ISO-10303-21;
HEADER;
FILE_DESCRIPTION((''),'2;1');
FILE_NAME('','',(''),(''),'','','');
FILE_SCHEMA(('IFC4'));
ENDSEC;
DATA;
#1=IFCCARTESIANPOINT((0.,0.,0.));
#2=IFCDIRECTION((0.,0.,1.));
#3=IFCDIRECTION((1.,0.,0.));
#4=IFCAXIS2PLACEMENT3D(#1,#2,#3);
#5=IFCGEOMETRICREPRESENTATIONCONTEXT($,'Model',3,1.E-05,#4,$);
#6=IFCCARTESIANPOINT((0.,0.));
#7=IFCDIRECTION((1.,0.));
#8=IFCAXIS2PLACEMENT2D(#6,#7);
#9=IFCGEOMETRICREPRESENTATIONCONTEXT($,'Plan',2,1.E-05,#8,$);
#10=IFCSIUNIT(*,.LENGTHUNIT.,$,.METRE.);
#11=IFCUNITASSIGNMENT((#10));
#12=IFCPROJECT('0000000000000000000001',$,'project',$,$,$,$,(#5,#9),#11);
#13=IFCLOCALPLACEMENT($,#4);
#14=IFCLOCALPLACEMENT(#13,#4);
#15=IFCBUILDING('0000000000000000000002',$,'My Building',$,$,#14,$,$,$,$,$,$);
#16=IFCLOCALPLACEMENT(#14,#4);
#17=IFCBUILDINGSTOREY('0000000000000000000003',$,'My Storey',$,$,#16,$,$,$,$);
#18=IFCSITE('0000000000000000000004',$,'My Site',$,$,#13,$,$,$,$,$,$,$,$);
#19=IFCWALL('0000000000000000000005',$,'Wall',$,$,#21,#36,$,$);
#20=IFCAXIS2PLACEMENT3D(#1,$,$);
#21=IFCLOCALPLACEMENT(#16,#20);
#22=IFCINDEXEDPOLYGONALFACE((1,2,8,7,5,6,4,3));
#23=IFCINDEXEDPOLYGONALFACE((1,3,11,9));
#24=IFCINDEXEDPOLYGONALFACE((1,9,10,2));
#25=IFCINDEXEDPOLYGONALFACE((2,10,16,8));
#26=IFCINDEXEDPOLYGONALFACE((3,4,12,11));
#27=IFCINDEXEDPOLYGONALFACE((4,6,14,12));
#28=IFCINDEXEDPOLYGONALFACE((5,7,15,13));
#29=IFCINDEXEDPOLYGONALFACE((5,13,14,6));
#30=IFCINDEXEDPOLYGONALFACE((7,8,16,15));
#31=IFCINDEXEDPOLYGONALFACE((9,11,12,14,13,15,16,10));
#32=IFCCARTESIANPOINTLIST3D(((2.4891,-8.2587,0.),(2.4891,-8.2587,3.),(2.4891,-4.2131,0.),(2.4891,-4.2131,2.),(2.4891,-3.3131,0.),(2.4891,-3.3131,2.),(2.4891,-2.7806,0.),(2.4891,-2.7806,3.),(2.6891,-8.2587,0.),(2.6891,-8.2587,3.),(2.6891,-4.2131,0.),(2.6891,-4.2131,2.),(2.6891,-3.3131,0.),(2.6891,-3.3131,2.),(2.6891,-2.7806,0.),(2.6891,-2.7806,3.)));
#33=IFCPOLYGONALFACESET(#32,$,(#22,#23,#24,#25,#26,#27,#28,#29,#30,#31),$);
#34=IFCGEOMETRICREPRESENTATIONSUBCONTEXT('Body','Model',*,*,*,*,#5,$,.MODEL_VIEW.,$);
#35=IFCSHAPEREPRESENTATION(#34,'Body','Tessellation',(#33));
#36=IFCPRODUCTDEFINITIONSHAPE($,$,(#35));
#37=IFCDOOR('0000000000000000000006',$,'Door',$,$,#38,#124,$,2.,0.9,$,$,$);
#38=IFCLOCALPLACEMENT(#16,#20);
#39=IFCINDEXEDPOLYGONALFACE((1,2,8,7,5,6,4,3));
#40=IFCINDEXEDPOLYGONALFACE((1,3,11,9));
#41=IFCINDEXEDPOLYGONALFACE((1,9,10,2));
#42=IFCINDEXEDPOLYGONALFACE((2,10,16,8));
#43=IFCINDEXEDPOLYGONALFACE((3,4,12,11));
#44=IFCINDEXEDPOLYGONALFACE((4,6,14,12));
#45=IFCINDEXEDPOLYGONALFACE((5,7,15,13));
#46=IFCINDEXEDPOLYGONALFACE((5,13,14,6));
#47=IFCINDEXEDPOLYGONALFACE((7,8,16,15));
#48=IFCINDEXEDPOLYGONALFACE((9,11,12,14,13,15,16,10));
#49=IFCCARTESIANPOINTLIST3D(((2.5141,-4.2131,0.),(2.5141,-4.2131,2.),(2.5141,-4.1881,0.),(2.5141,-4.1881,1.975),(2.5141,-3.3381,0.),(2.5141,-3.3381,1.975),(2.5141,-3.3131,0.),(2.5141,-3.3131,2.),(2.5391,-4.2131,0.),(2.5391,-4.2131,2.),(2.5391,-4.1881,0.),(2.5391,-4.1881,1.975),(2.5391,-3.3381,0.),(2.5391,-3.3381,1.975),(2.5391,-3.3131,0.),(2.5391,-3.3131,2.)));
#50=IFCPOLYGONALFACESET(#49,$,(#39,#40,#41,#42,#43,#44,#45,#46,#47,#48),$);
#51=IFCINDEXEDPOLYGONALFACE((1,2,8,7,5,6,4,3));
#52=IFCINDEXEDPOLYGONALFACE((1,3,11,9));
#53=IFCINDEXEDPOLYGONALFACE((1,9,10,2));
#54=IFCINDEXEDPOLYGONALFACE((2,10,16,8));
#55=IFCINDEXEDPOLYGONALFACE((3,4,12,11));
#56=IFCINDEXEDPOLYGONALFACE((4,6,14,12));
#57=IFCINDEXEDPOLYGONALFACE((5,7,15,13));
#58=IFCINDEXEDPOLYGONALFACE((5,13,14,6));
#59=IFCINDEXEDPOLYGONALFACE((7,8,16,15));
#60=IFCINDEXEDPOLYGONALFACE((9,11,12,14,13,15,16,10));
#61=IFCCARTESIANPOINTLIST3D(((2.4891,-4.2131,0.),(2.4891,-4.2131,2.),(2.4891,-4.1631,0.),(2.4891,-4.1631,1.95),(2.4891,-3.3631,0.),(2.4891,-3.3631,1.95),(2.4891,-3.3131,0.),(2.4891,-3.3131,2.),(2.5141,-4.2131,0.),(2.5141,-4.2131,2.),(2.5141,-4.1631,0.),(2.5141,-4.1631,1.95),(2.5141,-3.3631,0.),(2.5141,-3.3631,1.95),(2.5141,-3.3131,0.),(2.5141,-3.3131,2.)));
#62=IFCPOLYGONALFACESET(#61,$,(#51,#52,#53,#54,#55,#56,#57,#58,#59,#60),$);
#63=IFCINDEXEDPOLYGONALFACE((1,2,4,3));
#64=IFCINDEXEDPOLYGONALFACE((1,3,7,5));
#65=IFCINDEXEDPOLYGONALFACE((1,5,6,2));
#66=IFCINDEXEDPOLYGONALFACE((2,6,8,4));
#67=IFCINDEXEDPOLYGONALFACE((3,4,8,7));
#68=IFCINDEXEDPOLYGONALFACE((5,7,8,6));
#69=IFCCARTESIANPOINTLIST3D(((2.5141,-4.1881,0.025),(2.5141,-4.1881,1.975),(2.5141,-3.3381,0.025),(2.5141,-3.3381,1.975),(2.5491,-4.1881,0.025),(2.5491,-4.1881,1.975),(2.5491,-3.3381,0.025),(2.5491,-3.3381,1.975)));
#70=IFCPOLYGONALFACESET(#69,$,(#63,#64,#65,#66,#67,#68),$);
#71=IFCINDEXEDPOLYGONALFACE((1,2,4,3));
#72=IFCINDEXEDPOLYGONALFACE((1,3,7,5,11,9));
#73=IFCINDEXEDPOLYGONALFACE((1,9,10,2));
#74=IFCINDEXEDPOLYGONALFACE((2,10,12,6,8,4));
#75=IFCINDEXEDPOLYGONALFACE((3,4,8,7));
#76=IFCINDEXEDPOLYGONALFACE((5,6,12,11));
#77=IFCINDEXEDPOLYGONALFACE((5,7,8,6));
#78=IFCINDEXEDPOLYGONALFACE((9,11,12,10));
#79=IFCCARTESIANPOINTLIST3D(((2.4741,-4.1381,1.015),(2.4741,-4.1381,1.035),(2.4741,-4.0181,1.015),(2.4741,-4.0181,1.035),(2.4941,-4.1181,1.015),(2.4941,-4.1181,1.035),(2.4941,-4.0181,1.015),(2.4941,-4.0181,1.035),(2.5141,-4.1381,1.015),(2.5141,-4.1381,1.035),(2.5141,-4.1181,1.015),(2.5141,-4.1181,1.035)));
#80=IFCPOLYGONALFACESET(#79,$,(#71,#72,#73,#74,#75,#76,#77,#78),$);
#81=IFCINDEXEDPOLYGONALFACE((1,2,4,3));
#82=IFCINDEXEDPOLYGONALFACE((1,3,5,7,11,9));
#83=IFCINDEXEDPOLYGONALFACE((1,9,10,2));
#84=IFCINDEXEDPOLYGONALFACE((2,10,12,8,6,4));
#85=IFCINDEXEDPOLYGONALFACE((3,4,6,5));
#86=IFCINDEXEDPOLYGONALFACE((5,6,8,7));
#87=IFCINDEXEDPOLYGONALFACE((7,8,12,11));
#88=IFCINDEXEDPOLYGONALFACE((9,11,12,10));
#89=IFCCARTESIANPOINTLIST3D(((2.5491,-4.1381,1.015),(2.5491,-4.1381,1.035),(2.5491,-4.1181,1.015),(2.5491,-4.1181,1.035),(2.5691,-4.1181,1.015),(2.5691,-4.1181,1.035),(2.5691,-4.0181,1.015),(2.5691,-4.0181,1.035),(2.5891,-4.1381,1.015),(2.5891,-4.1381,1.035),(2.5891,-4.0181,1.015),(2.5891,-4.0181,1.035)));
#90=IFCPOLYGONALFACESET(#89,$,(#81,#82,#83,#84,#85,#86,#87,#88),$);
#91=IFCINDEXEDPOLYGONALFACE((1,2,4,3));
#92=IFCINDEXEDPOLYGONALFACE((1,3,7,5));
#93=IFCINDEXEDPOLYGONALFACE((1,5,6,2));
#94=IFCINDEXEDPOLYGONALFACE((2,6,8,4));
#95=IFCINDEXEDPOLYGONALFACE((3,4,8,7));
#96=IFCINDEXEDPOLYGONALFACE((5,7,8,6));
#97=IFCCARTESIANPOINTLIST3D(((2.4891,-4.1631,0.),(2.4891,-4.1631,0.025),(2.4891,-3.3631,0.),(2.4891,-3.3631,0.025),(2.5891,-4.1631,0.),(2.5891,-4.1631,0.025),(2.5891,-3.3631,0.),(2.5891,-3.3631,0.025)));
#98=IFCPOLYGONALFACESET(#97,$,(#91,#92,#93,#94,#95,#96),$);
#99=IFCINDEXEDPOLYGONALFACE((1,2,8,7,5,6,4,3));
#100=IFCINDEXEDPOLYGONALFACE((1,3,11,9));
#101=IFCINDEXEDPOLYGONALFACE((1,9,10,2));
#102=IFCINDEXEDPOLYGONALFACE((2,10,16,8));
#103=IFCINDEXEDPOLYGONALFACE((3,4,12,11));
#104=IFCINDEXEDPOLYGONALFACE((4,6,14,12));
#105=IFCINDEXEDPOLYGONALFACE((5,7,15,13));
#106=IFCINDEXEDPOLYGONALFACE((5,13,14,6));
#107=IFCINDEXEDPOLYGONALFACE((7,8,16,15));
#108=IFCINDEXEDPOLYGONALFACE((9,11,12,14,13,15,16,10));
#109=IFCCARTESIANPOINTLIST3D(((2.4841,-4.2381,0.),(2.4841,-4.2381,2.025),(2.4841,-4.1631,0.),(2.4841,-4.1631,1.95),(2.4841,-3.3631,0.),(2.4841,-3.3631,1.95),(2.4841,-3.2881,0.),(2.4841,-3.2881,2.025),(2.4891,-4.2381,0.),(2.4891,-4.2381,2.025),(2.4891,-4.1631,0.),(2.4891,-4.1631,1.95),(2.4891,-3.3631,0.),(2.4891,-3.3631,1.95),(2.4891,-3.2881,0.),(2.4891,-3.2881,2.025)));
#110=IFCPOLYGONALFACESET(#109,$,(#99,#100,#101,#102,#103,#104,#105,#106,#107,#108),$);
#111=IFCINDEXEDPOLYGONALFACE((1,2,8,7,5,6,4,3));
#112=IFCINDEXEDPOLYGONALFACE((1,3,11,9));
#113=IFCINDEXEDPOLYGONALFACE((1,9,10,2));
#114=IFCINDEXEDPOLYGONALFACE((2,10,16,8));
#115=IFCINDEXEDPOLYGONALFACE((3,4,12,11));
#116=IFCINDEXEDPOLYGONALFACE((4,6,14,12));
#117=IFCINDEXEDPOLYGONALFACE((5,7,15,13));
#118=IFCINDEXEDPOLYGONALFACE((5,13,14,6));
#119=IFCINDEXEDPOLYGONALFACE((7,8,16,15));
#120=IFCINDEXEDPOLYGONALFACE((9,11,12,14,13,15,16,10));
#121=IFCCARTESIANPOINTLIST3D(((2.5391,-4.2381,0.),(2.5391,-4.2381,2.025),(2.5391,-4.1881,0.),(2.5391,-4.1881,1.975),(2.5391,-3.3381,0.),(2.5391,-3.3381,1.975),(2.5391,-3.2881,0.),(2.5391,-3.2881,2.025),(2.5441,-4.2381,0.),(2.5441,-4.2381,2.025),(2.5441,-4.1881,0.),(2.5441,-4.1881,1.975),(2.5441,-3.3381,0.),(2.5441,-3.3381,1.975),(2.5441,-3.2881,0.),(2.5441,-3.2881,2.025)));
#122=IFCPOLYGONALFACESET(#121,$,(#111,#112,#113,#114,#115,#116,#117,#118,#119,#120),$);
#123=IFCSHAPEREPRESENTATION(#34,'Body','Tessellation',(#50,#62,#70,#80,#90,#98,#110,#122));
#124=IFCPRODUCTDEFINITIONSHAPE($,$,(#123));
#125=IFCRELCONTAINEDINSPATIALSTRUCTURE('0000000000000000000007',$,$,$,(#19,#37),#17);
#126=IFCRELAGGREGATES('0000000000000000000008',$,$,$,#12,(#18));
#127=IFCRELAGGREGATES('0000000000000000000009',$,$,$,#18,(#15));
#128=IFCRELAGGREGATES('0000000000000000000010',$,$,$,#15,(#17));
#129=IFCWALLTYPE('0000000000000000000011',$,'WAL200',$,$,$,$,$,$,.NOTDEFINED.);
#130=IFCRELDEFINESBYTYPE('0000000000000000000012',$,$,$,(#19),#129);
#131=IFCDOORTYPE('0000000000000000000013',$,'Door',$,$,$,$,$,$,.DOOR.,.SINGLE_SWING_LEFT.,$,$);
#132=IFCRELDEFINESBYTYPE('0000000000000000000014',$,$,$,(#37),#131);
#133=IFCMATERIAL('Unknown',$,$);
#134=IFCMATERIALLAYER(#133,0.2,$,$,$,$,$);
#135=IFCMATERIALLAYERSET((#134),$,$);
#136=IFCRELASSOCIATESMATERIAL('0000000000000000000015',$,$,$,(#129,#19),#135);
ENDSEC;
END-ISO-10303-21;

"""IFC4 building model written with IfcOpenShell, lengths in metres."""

from ifc_helpers import new_model, entity, si_unit, frame, origin_with_axes, origin_2d_with_axis, place, context, subcontext, project, spatial, line, indexed_curve, outline, extrude, shape, source, transform, mapped, material, layer, layer_set, layer_usage, type_object, type_shapes, element, fill, save


model = new_model("IFC4")

# Units and contexts
model_context = context("Model", 3, precision=1e-05, world=origin_with_axes())
plan_context = context("Plan", 2, precision=1e-05, world=origin_2d_with_axis())
body_context_1 = subcontext(model_context, "Body", "Model", "MODEL_VIEW")
body_context_2 = subcontext(plan_context, "Body", "Plan", "PLAN_VIEW")
ifc_project = project(units=[si_unit("LENGTHUNIT", "METRE")], contexts=[model_context, plan_context])

# Site, building, storey
site_placement = place(None, origin_with_axes())
site = spatial("IfcSite", under=ifc_project, at=site_placement, Name="My Site")
building_placement = place(site_placement, origin_with_axes())
building = spatial("IfcBuilding", under=site, at=building_placement, Name="My Building")
storey_placement = place(building_placement, origin_with_axes())
storey = spatial("IfcBuildingStorey", under=building, at=storey_placement, Name="My Storey")

# Shared definitions
ifc_material = material(Name="Unknown")
ifc_layer = layer(ifc_material, 0.2)
ifc_layer_set = layer_set([ifc_layer])
wall_type = type_object("IfcWallType", Name="WAL200", PredefinedType="NOTDEFINED", material=ifc_layer_set)

# Wall, opening, door
ifc_layer_usage_1 = layer_usage(ifc_layer_set, "AXIS2", "POSITIVE", 0.0)
wall_1_placement = place(storey_placement, frame((2.6891, -8.2587, 0.0), z_axis=(0.0, 0.0, 1.0), x_axis=(0.0, 1.0, 0.0)))
wall_1 = element("IfcWall", 1, at=wall_1_placement, inside=storey, type_object=wall_type, material=ifc_layer_usage_1, Name="Wall", context=body_context_1, shape_type="SweptSolid", body=[
    extrude(outline(indexed_curve([(0.0, 0.0), (0.0, 0.2), (5.478, 0.2), (5.478, 0.0)], segments=[line(1, 2, 3, 4, 1)])), origin_with_axes(), (0.0, 0.0, 1.0), 3.0),
])
shared_shape_1 = source(origin_with_axes(), body_context_1, "Body", "SweptSolid", [
    extrude(outline(indexed_curve([(0.0, 0.0), (0.9, 0.0), (0.9, 2.0), (0.0, 2.0)], segments=[line(1, 2, 3, 4, 1)])), frame((0.0, -0.6, 0.0), z_axis=(0.0, -1.0, 0.0), x_axis=(1.0, 0.0, 0.0)), (0.0, 0.0, -1.0), 1.2),
])
opening_1_placement = place(wall_1_placement, frame((4.9456, 0.2, 0.0), z_axis=(0.0, 0.0, 1.0), x_axis=(-1.0, 0.0, 0.0)))
opening_1 = element("IfcOpeningElement", 2, at=opening_1_placement, cuts=wall_1, PredefinedType="OPENING", context=body_context_1, shape_type="MappedRepresentation", body=[
    mapped(shared_shape_1, transform((0.0, 0.0, 0.0), x_axis=(1.0, 0.0, 0.0), y_axis=(0.0, 1.0, 0.0), z_axis=(0.0, 0.0, 1.0), scale=1.0)),
])
door_type_1 = type_object("IfcDoorType", Name="Door", OperationType="SINGLE_SWING_LEFT", PredefinedType="DOOR")
shared_shape_2 = source(origin_with_axes(), body_context_1, "Body", "SweptSolid", [
    extrude(outline(indexed_curve([(0.0, 0.0), (0.0, 2.0), (0.9, 2.0), (0.9, 0.0), (0.875, 0.0), (0.875, 1.975), (0.025, 1.975), (0.025, 0.0)], segments=[line(1, 2, 3, 4, 5, 6, 7, 8, 1)])), frame((0.0, 0.025, 0.0), z_axis=(0.0, -1.0, 0.0), x_axis=(1.0, 0.0, 0.0)), (0.0, 0.0, -1.0), 0.025),
    extrude(outline(indexed_curve([(0.0, 0.0), (0.0, 2.0), (0.9, 2.0), (0.9, 0.0), (0.85, 0.0), (0.85, 1.95), (0.05, 1.95), (0.05, 0.0)], segments=[line(1, 2, 3, 4, 5, 6, 7, 8, 1)])), frame((0.0, 0.0, 0.0), z_axis=(0.0, -1.0, 0.0), x_axis=(1.0, 0.0, 0.0)), (0.0, 0.0, -1.0), 0.025),
    extrude(outline(indexed_curve([(0.0, 0.0), (0.85, 0.0), (0.85, 0.035), (0.0, 0.035)], segments=[line(1, 2, 3, 4, 1)])), frame((0.025, 0.025, 0.025), z_axis=(0.0, 0.0, 1.0), x_axis=(1.0, 0.0, 0.0)), (0.0, 0.0, 1.0), 1.95),
    extrude(outline(indexed_curve([(0.0, 0.0), (0.0, -0.04), (-0.12, -0.04), (-0.12, -0.02), (-0.02, -0.02), (-0.02, 0.0)], segments=[line(1, 2, 3, 4, 5, 6, 1)])), frame((0.825, 0.025, 1.015), z_axis=(0.0, 0.0, 1.0), x_axis=(1.0, 0.0, 0.0)), (0.0, 0.0, 1.0), 0.02),
    extrude(outline(indexed_curve([(0.0, 0.0), (0.0, 0.04), (-0.12, 0.04), (-0.12, 0.02), (-0.02, 0.02), (-0.02, 0.0)], segments=[line(1, 2, 3, 4, 5, 6, 1)])), frame((0.825, 0.06, 1.015), z_axis=(0.0, 0.0, 1.0), x_axis=(1.0, 0.0, 0.0)), (0.0, 0.0, 1.0), 0.02),
    extrude(outline(indexed_curve([(0.0, 0.0), (0.8, 0.0), (0.8, 0.1), (0.0, 0.1)], segments=[line(1, 2, 3, 4, 1)])), frame((0.05, 0.0, 0.0), z_axis=(0.0, 0.0, 1.0), x_axis=(1.0, 0.0, 0.0)), (0.0, 0.0, 1.0), 0.025),
    extrude(outline(indexed_curve([(0.0, 0.0), (0.0, 2.025), (0.95, 2.025), (0.95, 0.0), (0.875, 0.0), (0.875, 1.95), (0.075, 1.95), (0.075, 0.0)], segments=[line(1, 2, 3, 4, 5, 6, 7, 8, 1)])), frame((-0.025, -0.005, 0.0), z_axis=(0.0, -1.0, 0.0), x_axis=(1.0, 0.0, 0.0)), (0.0, 0.0, -1.0), 0.005),
    extrude(outline(indexed_curve([(0.0, 0.0), (0.0, 2.025), (0.95, 2.025), (0.95, 0.0), (0.9, 0.0), (0.9, 1.975), (0.05, 1.975), (0.05, 0.0)], segments=[line(1, 2, 3, 4, 5, 6, 7, 8, 1)])), frame((-0.025, 0.05, 0.0), z_axis=(0.0, -1.0, 0.0), x_axis=(1.0, 0.0, 0.0)), (0.0, 0.0, -1.0), 0.005),
])
shared_shape_3 = source(origin_with_axes(), body_context_2, "Body", "Curve2D", [
    entity("IfcIndexedPolyCurve", entity("IfcCartesianPointList2D", [[0.0, 0.0], [0.0, 0.05], [0.025, 0.05], [0.025, 0.025], [0.05, 0.025], [0.05, 0.0]]), [entity("IfcLineIndex", [1, 2, 3, 4, 5, 6, 1])]),
    entity("IfcIndexedPolyCurve", entity("IfcCartesianPointList2D", [[0.9, 0.0], [0.9, 0.05], [0.875, 0.05], [0.875, 0.025], [0.85, 0.025], [0.85, 0.0]]), [entity("IfcLineIndex", [1, 2, 3, 4, 5, 6, 1])]),
    entity("IfcTrimmedCurve", entity("IfcEllipse", entity("IfcAxis2Placement2D", entity("IfcCartesianPoint", [0.06, 0.05]), entity("IfcDirection", [1.0, 0.0])), 0.815, 0.85), [entity("IfcCartesianPoint", [0.875, 0.05])], [entity("IfcCartesianPoint", [0.06, 0.9])], True, "CARTESIAN"),
    entity("IfcIndexedPolyCurve", entity("IfcCartesianPointList2D", [[0.025, 0.05], [0.06, 0.05], [0.06, 0.9], [0.025, 0.9]]), [entity("IfcLineIndex", [1, 2, 3, 4, 1])]),
])
type_shapes(door_type_1, [shared_shape_2, shared_shape_3])
door_1_placement = place(opening_1_placement, frame((0.0, 0.0, 0.0), z_axis=(0.0, 0.0, 1.0), x_axis=(1.0, 0.0, 0.0)))
door_1 = element("IfcDoor", 3, at=door_1_placement, inside=storey, type_object=door_type_1, Name="Door", OverallHeight=2.0, OverallWidth=0.9, shapes=[
    shape(body_context_1, "Body", "MappedRepresentation", [mapped(shared_shape_2, transform((0.0, 0.0, 0.0), x_axis=(1.0, 0.0, 0.0), y_axis=(0.0, 1.0, 0.0), z_axis=(0.0, 0.0, 1.0), scale=1.0))]),
    shape(body_context_2, "Body", "MappedRepresentation", [mapped(shared_shape_3, transform((0.0, 0.0, 0.0), x_axis=(1.0, 0.0, 0.0), y_axis=(0.0, 1.0, 0.0), z_axis=(0.0, 0.0, 1.0), scale=1.0))]),
])
fill(opening_1, door_1)

save(model, "model.ifc")
